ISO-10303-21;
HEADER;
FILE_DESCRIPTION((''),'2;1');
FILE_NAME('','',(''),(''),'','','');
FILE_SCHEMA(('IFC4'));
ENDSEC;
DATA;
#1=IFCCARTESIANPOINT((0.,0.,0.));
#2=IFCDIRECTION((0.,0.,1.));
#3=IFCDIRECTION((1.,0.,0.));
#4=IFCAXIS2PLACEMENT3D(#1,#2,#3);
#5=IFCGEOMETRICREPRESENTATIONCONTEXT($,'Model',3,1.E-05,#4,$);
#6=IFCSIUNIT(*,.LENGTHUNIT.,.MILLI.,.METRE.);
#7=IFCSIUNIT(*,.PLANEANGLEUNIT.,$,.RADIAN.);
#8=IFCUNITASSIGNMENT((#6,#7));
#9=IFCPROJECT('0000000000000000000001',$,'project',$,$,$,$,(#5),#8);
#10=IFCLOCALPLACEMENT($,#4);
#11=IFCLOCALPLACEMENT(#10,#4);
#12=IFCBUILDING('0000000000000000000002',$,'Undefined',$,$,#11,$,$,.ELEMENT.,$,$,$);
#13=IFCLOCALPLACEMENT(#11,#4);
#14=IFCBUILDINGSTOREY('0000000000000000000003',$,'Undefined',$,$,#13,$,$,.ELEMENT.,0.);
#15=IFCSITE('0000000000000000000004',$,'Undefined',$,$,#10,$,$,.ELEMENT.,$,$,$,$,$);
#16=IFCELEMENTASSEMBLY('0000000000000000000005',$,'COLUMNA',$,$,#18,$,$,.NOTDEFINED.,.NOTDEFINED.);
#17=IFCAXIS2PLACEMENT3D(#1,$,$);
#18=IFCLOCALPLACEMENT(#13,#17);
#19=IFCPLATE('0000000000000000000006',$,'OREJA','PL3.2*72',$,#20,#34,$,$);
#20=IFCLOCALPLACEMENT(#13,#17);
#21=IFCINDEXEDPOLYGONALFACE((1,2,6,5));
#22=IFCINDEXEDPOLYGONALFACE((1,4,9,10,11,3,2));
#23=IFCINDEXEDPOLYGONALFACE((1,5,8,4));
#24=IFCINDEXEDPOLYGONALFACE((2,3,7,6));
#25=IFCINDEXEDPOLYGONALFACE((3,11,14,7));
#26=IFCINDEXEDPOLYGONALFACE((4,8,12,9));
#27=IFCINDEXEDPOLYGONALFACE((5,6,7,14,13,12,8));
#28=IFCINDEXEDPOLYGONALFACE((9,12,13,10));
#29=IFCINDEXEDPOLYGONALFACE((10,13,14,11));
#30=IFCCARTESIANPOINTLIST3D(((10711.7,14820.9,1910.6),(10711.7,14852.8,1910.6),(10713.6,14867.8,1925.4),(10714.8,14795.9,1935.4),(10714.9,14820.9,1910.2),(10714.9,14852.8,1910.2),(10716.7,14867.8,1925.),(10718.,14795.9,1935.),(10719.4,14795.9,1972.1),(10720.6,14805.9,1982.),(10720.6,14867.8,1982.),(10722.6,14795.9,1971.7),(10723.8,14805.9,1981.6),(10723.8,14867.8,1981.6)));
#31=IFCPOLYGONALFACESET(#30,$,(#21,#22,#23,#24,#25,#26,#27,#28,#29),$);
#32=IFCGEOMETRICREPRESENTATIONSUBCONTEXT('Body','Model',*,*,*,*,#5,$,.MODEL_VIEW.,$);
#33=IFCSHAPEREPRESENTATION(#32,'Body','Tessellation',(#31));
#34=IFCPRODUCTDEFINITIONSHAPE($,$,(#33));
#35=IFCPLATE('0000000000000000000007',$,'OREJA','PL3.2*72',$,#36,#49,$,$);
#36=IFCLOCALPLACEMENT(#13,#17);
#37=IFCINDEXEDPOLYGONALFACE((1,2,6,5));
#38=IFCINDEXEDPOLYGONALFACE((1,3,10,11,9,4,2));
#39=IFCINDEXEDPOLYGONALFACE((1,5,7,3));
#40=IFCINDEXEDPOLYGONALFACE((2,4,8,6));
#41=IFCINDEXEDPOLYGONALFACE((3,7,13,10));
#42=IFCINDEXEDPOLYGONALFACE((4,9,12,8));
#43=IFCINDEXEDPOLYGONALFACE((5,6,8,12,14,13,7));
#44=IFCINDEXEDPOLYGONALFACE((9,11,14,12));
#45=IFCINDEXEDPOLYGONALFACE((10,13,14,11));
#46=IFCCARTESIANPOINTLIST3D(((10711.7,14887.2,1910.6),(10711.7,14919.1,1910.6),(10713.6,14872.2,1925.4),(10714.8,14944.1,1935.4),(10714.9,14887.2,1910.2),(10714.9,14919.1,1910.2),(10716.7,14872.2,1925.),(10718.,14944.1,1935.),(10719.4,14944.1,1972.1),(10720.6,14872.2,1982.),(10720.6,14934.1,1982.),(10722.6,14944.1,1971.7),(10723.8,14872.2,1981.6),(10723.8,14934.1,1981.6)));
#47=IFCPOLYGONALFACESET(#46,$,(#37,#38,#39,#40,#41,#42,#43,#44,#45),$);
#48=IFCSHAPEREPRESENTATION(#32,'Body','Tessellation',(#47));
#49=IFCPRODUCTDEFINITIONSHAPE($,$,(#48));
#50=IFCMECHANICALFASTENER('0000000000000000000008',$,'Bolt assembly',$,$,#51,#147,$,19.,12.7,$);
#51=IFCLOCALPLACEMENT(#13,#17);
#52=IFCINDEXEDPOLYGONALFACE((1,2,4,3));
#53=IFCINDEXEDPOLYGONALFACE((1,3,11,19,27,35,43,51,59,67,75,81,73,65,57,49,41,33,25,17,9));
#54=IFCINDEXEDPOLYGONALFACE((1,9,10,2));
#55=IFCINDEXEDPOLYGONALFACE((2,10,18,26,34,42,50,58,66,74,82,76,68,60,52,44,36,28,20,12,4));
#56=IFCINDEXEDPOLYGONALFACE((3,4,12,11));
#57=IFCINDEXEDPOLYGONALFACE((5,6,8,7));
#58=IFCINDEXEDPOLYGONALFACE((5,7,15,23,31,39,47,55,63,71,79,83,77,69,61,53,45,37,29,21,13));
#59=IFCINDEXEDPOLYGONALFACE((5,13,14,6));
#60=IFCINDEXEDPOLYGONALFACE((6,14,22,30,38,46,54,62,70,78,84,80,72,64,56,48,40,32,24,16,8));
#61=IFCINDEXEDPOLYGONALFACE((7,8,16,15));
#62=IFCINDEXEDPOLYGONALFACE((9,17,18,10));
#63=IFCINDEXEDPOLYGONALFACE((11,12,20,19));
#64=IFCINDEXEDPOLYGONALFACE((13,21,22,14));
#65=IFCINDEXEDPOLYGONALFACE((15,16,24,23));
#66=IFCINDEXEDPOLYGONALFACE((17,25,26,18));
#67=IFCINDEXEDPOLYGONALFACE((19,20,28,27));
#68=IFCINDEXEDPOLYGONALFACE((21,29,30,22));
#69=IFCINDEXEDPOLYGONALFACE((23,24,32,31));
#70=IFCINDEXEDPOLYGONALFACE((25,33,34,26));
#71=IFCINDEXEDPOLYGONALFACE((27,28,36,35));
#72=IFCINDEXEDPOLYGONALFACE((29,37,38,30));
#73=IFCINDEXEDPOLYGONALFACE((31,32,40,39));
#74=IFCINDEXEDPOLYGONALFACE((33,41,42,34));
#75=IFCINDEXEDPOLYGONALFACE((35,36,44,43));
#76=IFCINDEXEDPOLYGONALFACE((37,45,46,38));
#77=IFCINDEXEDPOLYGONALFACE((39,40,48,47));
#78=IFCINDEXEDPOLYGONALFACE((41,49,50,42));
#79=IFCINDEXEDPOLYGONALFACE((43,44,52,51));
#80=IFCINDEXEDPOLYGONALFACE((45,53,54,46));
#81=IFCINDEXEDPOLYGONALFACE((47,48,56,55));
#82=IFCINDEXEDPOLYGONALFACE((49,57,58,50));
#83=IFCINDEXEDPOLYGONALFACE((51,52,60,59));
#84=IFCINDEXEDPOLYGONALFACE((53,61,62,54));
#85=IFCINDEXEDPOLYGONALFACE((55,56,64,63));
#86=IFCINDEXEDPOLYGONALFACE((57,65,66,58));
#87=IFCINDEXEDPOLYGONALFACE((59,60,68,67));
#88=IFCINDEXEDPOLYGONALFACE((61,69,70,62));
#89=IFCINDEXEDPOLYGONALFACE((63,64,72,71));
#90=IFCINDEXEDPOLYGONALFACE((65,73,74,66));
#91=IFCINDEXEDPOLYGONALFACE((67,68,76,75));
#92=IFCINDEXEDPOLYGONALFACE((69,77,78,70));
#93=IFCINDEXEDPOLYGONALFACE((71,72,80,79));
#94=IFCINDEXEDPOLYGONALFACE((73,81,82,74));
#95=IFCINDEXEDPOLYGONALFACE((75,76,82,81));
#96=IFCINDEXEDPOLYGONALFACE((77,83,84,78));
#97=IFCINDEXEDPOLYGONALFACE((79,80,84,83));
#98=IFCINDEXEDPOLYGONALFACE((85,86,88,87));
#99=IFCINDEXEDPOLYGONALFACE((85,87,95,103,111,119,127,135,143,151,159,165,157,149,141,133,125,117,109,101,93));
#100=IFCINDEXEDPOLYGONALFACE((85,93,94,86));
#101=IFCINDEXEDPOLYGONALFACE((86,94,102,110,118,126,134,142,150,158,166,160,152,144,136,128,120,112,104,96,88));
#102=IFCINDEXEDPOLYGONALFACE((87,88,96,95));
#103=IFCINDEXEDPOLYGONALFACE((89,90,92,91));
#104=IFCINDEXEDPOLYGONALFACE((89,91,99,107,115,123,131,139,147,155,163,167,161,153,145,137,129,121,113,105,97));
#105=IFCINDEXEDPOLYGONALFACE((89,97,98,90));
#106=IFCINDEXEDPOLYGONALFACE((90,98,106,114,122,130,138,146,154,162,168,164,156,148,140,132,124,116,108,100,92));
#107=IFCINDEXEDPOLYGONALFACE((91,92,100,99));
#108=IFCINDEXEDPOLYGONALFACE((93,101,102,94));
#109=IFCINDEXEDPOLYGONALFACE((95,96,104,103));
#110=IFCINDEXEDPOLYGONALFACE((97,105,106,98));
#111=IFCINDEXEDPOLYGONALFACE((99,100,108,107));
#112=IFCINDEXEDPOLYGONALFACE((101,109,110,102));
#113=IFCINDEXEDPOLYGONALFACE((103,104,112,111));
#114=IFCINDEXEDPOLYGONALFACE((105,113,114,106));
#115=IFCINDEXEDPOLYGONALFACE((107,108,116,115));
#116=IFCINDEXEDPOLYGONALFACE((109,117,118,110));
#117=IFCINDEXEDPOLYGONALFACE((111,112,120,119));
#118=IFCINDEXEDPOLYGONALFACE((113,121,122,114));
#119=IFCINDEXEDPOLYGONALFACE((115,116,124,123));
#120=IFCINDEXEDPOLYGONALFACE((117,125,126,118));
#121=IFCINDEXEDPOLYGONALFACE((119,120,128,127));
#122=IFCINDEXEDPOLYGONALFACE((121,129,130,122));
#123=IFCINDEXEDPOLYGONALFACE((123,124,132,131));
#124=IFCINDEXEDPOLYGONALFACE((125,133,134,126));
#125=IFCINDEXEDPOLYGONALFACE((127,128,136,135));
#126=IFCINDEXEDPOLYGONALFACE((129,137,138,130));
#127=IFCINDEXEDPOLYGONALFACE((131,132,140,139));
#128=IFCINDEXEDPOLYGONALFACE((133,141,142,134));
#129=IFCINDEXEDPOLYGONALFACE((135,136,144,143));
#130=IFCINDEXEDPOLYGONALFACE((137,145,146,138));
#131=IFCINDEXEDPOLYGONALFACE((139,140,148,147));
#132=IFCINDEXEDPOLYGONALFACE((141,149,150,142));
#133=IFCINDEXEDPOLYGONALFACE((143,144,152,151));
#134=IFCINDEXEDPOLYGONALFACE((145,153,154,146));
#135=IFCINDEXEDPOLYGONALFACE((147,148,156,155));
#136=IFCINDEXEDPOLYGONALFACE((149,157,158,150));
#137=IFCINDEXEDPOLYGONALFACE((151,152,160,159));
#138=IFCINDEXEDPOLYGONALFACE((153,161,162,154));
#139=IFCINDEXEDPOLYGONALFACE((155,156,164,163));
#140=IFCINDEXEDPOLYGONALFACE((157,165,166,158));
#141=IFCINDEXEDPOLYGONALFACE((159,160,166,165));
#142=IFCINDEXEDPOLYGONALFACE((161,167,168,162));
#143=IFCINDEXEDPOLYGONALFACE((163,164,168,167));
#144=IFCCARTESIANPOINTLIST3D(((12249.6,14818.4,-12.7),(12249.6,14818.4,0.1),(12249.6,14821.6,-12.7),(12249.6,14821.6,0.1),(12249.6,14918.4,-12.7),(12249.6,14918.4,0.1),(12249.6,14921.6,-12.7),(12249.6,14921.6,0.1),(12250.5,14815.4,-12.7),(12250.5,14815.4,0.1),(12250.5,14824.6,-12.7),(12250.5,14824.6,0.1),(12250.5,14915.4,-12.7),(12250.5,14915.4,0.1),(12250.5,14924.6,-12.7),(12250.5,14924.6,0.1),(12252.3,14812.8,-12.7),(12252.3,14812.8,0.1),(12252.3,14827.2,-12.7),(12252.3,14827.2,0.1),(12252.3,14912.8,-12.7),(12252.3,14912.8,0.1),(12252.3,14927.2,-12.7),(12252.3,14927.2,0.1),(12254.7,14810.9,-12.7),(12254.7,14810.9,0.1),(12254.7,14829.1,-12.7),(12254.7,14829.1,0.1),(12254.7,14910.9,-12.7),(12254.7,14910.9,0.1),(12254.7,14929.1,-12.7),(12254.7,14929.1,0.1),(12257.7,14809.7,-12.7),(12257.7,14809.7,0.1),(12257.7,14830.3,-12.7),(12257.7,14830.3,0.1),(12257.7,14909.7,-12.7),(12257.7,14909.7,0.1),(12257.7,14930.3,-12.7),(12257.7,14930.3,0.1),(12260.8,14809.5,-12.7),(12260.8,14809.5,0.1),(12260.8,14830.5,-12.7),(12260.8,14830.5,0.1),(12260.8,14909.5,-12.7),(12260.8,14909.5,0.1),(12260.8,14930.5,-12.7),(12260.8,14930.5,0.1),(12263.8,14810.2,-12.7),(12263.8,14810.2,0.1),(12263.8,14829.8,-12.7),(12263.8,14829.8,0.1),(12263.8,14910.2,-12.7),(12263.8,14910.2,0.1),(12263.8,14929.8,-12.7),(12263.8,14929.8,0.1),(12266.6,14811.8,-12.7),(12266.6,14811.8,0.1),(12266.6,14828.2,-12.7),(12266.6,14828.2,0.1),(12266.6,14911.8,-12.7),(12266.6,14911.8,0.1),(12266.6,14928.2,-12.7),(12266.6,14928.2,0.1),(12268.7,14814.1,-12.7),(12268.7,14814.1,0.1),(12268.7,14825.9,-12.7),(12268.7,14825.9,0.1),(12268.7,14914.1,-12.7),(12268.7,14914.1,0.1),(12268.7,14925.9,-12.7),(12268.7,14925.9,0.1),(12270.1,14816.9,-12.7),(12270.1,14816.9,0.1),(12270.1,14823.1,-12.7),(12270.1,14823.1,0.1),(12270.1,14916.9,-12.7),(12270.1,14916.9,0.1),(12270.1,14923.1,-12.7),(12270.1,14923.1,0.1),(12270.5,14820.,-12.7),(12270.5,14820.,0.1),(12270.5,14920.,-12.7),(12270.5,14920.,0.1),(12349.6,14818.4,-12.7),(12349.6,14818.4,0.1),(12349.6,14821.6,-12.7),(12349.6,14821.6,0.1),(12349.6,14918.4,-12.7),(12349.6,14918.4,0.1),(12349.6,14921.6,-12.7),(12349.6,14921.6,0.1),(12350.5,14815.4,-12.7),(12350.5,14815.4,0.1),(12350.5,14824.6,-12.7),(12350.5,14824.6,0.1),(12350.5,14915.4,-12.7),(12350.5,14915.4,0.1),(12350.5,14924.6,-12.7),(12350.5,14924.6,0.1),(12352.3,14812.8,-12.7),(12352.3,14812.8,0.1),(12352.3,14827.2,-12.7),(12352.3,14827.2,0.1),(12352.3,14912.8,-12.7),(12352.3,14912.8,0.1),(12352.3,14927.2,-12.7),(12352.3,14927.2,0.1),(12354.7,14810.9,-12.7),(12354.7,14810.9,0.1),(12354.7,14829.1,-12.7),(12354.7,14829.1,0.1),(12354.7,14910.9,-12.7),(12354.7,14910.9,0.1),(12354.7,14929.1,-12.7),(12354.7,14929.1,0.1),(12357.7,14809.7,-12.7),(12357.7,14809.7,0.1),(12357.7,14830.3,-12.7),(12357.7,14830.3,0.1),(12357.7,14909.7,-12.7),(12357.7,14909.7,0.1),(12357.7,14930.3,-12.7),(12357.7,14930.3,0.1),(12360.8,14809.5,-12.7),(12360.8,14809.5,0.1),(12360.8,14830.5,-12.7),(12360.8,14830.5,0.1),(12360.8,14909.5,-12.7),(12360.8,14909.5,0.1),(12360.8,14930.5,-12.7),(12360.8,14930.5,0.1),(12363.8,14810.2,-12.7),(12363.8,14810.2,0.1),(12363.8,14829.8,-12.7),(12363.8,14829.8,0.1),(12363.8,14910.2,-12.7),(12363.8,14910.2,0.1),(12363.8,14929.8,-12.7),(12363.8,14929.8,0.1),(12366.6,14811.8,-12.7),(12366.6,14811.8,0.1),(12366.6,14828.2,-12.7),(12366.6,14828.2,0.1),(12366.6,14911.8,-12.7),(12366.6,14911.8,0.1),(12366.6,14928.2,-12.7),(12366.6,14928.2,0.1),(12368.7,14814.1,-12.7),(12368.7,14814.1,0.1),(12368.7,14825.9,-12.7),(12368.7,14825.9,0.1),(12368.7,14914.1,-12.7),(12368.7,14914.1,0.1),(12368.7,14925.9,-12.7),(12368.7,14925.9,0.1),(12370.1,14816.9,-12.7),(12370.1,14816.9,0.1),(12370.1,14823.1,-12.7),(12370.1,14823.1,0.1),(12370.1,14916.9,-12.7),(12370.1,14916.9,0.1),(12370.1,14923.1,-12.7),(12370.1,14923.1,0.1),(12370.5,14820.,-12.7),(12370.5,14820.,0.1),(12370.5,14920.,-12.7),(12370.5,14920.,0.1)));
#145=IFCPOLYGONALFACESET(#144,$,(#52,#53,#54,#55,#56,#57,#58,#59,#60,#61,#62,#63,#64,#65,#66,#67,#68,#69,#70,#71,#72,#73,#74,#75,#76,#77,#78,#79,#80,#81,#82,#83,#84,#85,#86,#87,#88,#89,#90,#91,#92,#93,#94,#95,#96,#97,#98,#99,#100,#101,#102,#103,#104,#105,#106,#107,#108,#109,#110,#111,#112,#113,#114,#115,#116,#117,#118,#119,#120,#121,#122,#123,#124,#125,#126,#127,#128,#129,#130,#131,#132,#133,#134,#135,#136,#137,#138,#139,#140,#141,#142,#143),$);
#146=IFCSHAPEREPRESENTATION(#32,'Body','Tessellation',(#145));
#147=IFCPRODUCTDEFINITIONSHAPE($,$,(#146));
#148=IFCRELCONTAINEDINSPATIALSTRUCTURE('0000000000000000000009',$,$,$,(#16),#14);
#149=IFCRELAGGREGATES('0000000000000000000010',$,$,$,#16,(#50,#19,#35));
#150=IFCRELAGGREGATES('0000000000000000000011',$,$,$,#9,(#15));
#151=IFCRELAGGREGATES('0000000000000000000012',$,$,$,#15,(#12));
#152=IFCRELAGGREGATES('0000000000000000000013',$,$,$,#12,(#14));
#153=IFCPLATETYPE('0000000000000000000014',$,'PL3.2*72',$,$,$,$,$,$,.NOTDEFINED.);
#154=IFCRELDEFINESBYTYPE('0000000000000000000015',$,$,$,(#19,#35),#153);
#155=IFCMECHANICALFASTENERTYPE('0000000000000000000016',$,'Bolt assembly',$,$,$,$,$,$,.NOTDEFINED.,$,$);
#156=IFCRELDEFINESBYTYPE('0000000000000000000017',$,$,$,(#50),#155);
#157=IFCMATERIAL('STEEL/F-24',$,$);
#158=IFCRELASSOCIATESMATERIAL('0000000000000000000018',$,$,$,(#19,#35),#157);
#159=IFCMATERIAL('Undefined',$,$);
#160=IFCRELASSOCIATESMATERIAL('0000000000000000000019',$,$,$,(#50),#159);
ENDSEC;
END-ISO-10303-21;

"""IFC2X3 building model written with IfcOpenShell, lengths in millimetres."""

from ifc_helpers import new_model, si_unit, frame, origin_with_axes, origin_2d_with_axis, place, context, subcontext, project, spatial, polyline, circle, outline, extrude, source, transform, mapped, material, type_object, element, aggregate, save


model = new_model("IFC2X3")

# Units and contexts
model_context = context("Model", 3, precision=1e-05, world=origin_with_axes())
body_context = subcontext(model_context, "Body", "Model", "MODEL_VIEW")
ifc_project = project(units=[si_unit("LENGTHUNIT", "METRE", prefix="MILLI"), si_unit("PLANEANGLEUNIT", "RADIAN")], contexts=[model_context])

# Site, building, storey
site_placement = place(None, origin_with_axes())
site = spatial("IfcSite", under=ifc_project, at=site_placement, Name="Undefined", CompositionType="ELEMENT")
building_placement = place(site_placement, origin_with_axes())
building = spatial("IfcBuilding", under=site, at=building_placement, Name="Undefined", CompositionType="ELEMENT")
storey_placement = place(building_placement, origin_with_axes())
storey = spatial("IfcBuildingStorey", under=building, at=storey_placement, Name="Undefined", CompositionType="ELEMENT", Elevation=0.0)

# Element assembly
assembly_1_placement = place(storey_placement, origin_with_axes())
assembly_1 = element("IfcElementAssembly", 1, at=assembly_1_placement, inside=storey, Name="COLUMNA", AssemblyPlace="NOTDEFINED", PredefinedType="NOTDEFINED")
ifc_material_1 = material(Name="STEEL/F-24")

# Plates
plate_type_1 = type_object("IfcPlateType", Name="PL3.2*72", PredefinedType="NOTDEFINED")
plate_1_placement = place(assembly_1_placement, frame((10713.3, 14867.8, 1910.4), z_axis=(-0.992251, 0.0, 0.124252), x_axis=(0.0, -1.0, 0.0)))
plate_1 = element("IfcPlate", 2, at=plate_1_placement, type_object=plate_type_1, material=ifc_material_1, Name="OREJA", Description="PL3.2*72", context=body_context, shape_type="SweptSolid", body=[
    extrude(outline(polyline([(0.0, 15.0), (15.0, 0.0), (47.0, 0.0), (72.0, 25.0), (72.0, 62.0), (62.0, 72.0), (0.0, 72.0), (0.0, 15.0)])), frame((0.0, 0.0, -1.6), z_axis=(0.0, 0.0, 1.0), x_axis=(1.0, 0.0, 0.0)), (0.0, 0.0, 1.0), 3.2),
])
plate_2_placement = place(assembly_1_placement, frame((10713.3, 14872.2, 1910.4), z_axis=(0.992251, 0.0, -0.124252), x_axis=(0.0, 1.0, 0.0)))
plate_2 = element("IfcPlate", 3, at=plate_2_placement, type_object=plate_type_1, material=ifc_material_1, Name="OREJA", Description="PL3.2*72", context=body_context, shape_type="SweptSolid", body=[
    extrude(outline(polyline([(0.0, 15.0), (15.0, 0.0), (47.0, 0.0), (72.0, 25.0), (72.0, 62.0), (62.0, 72.0), (0.0, 72.0), (0.0, 15.0)])), frame((0.0, 0.0, -1.6), z_axis=(0.0, 0.0, 1.0), x_axis=(1.0, 0.0, 0.0)), (0.0, 0.0, 1.0), 3.2),
])

# Shared definitions
ifc_material_2 = material(Name="Undefined")
mechanical_fastener_type = type_object("IfcMechanicalFastenerType", Name="Bolt assembly")

# Mechanical fastener
shared_shape_1 = source(origin_with_axes(), body_context, "Body", "SweptSolid", [
    extrude(circle(Radius=10.5, at=origin_2d_with_axis()), frame((0.0, -22.7, 0.0), z_axis=(0.0, 1.0, 0.0), x_axis=(1.0, 0.0, 0.0)), (0.0, 0.0, 1.0), 12.8),
])
mechanical_fastener_1_placement = place(assembly_1_placement, frame((12260.0, 14870.0, 10.0), z_axis=(0.0, -1.0, 0.0), x_axis=(1.0, 0.0, 0.0)))
mechanical_fastener_1 = element("IfcMechanicalFastener", 4, at=mechanical_fastener_1_placement, type_object=mechanical_fastener_type, material=ifc_material_2, Name="Bolt assembly", NominalDiameter=19.0, NominalLength=12.7, context=body_context, shape_type="MappedRepresentation", body=[
    mapped(shared_shape_1, transform((0.0, 0.0, -50.0))),
    mapped(shared_shape_1, transform((100.0, 0.0, -50.0))),
    mapped(shared_shape_1, transform((0.0, 0.0, 50.0))),
    mapped(shared_shape_1, transform((100.0, 0.0, 50.0))),
])

aggregate(assembly_1, [mechanical_fastener_1, plate_1, plate_2])

save(model, "model.ifc")
